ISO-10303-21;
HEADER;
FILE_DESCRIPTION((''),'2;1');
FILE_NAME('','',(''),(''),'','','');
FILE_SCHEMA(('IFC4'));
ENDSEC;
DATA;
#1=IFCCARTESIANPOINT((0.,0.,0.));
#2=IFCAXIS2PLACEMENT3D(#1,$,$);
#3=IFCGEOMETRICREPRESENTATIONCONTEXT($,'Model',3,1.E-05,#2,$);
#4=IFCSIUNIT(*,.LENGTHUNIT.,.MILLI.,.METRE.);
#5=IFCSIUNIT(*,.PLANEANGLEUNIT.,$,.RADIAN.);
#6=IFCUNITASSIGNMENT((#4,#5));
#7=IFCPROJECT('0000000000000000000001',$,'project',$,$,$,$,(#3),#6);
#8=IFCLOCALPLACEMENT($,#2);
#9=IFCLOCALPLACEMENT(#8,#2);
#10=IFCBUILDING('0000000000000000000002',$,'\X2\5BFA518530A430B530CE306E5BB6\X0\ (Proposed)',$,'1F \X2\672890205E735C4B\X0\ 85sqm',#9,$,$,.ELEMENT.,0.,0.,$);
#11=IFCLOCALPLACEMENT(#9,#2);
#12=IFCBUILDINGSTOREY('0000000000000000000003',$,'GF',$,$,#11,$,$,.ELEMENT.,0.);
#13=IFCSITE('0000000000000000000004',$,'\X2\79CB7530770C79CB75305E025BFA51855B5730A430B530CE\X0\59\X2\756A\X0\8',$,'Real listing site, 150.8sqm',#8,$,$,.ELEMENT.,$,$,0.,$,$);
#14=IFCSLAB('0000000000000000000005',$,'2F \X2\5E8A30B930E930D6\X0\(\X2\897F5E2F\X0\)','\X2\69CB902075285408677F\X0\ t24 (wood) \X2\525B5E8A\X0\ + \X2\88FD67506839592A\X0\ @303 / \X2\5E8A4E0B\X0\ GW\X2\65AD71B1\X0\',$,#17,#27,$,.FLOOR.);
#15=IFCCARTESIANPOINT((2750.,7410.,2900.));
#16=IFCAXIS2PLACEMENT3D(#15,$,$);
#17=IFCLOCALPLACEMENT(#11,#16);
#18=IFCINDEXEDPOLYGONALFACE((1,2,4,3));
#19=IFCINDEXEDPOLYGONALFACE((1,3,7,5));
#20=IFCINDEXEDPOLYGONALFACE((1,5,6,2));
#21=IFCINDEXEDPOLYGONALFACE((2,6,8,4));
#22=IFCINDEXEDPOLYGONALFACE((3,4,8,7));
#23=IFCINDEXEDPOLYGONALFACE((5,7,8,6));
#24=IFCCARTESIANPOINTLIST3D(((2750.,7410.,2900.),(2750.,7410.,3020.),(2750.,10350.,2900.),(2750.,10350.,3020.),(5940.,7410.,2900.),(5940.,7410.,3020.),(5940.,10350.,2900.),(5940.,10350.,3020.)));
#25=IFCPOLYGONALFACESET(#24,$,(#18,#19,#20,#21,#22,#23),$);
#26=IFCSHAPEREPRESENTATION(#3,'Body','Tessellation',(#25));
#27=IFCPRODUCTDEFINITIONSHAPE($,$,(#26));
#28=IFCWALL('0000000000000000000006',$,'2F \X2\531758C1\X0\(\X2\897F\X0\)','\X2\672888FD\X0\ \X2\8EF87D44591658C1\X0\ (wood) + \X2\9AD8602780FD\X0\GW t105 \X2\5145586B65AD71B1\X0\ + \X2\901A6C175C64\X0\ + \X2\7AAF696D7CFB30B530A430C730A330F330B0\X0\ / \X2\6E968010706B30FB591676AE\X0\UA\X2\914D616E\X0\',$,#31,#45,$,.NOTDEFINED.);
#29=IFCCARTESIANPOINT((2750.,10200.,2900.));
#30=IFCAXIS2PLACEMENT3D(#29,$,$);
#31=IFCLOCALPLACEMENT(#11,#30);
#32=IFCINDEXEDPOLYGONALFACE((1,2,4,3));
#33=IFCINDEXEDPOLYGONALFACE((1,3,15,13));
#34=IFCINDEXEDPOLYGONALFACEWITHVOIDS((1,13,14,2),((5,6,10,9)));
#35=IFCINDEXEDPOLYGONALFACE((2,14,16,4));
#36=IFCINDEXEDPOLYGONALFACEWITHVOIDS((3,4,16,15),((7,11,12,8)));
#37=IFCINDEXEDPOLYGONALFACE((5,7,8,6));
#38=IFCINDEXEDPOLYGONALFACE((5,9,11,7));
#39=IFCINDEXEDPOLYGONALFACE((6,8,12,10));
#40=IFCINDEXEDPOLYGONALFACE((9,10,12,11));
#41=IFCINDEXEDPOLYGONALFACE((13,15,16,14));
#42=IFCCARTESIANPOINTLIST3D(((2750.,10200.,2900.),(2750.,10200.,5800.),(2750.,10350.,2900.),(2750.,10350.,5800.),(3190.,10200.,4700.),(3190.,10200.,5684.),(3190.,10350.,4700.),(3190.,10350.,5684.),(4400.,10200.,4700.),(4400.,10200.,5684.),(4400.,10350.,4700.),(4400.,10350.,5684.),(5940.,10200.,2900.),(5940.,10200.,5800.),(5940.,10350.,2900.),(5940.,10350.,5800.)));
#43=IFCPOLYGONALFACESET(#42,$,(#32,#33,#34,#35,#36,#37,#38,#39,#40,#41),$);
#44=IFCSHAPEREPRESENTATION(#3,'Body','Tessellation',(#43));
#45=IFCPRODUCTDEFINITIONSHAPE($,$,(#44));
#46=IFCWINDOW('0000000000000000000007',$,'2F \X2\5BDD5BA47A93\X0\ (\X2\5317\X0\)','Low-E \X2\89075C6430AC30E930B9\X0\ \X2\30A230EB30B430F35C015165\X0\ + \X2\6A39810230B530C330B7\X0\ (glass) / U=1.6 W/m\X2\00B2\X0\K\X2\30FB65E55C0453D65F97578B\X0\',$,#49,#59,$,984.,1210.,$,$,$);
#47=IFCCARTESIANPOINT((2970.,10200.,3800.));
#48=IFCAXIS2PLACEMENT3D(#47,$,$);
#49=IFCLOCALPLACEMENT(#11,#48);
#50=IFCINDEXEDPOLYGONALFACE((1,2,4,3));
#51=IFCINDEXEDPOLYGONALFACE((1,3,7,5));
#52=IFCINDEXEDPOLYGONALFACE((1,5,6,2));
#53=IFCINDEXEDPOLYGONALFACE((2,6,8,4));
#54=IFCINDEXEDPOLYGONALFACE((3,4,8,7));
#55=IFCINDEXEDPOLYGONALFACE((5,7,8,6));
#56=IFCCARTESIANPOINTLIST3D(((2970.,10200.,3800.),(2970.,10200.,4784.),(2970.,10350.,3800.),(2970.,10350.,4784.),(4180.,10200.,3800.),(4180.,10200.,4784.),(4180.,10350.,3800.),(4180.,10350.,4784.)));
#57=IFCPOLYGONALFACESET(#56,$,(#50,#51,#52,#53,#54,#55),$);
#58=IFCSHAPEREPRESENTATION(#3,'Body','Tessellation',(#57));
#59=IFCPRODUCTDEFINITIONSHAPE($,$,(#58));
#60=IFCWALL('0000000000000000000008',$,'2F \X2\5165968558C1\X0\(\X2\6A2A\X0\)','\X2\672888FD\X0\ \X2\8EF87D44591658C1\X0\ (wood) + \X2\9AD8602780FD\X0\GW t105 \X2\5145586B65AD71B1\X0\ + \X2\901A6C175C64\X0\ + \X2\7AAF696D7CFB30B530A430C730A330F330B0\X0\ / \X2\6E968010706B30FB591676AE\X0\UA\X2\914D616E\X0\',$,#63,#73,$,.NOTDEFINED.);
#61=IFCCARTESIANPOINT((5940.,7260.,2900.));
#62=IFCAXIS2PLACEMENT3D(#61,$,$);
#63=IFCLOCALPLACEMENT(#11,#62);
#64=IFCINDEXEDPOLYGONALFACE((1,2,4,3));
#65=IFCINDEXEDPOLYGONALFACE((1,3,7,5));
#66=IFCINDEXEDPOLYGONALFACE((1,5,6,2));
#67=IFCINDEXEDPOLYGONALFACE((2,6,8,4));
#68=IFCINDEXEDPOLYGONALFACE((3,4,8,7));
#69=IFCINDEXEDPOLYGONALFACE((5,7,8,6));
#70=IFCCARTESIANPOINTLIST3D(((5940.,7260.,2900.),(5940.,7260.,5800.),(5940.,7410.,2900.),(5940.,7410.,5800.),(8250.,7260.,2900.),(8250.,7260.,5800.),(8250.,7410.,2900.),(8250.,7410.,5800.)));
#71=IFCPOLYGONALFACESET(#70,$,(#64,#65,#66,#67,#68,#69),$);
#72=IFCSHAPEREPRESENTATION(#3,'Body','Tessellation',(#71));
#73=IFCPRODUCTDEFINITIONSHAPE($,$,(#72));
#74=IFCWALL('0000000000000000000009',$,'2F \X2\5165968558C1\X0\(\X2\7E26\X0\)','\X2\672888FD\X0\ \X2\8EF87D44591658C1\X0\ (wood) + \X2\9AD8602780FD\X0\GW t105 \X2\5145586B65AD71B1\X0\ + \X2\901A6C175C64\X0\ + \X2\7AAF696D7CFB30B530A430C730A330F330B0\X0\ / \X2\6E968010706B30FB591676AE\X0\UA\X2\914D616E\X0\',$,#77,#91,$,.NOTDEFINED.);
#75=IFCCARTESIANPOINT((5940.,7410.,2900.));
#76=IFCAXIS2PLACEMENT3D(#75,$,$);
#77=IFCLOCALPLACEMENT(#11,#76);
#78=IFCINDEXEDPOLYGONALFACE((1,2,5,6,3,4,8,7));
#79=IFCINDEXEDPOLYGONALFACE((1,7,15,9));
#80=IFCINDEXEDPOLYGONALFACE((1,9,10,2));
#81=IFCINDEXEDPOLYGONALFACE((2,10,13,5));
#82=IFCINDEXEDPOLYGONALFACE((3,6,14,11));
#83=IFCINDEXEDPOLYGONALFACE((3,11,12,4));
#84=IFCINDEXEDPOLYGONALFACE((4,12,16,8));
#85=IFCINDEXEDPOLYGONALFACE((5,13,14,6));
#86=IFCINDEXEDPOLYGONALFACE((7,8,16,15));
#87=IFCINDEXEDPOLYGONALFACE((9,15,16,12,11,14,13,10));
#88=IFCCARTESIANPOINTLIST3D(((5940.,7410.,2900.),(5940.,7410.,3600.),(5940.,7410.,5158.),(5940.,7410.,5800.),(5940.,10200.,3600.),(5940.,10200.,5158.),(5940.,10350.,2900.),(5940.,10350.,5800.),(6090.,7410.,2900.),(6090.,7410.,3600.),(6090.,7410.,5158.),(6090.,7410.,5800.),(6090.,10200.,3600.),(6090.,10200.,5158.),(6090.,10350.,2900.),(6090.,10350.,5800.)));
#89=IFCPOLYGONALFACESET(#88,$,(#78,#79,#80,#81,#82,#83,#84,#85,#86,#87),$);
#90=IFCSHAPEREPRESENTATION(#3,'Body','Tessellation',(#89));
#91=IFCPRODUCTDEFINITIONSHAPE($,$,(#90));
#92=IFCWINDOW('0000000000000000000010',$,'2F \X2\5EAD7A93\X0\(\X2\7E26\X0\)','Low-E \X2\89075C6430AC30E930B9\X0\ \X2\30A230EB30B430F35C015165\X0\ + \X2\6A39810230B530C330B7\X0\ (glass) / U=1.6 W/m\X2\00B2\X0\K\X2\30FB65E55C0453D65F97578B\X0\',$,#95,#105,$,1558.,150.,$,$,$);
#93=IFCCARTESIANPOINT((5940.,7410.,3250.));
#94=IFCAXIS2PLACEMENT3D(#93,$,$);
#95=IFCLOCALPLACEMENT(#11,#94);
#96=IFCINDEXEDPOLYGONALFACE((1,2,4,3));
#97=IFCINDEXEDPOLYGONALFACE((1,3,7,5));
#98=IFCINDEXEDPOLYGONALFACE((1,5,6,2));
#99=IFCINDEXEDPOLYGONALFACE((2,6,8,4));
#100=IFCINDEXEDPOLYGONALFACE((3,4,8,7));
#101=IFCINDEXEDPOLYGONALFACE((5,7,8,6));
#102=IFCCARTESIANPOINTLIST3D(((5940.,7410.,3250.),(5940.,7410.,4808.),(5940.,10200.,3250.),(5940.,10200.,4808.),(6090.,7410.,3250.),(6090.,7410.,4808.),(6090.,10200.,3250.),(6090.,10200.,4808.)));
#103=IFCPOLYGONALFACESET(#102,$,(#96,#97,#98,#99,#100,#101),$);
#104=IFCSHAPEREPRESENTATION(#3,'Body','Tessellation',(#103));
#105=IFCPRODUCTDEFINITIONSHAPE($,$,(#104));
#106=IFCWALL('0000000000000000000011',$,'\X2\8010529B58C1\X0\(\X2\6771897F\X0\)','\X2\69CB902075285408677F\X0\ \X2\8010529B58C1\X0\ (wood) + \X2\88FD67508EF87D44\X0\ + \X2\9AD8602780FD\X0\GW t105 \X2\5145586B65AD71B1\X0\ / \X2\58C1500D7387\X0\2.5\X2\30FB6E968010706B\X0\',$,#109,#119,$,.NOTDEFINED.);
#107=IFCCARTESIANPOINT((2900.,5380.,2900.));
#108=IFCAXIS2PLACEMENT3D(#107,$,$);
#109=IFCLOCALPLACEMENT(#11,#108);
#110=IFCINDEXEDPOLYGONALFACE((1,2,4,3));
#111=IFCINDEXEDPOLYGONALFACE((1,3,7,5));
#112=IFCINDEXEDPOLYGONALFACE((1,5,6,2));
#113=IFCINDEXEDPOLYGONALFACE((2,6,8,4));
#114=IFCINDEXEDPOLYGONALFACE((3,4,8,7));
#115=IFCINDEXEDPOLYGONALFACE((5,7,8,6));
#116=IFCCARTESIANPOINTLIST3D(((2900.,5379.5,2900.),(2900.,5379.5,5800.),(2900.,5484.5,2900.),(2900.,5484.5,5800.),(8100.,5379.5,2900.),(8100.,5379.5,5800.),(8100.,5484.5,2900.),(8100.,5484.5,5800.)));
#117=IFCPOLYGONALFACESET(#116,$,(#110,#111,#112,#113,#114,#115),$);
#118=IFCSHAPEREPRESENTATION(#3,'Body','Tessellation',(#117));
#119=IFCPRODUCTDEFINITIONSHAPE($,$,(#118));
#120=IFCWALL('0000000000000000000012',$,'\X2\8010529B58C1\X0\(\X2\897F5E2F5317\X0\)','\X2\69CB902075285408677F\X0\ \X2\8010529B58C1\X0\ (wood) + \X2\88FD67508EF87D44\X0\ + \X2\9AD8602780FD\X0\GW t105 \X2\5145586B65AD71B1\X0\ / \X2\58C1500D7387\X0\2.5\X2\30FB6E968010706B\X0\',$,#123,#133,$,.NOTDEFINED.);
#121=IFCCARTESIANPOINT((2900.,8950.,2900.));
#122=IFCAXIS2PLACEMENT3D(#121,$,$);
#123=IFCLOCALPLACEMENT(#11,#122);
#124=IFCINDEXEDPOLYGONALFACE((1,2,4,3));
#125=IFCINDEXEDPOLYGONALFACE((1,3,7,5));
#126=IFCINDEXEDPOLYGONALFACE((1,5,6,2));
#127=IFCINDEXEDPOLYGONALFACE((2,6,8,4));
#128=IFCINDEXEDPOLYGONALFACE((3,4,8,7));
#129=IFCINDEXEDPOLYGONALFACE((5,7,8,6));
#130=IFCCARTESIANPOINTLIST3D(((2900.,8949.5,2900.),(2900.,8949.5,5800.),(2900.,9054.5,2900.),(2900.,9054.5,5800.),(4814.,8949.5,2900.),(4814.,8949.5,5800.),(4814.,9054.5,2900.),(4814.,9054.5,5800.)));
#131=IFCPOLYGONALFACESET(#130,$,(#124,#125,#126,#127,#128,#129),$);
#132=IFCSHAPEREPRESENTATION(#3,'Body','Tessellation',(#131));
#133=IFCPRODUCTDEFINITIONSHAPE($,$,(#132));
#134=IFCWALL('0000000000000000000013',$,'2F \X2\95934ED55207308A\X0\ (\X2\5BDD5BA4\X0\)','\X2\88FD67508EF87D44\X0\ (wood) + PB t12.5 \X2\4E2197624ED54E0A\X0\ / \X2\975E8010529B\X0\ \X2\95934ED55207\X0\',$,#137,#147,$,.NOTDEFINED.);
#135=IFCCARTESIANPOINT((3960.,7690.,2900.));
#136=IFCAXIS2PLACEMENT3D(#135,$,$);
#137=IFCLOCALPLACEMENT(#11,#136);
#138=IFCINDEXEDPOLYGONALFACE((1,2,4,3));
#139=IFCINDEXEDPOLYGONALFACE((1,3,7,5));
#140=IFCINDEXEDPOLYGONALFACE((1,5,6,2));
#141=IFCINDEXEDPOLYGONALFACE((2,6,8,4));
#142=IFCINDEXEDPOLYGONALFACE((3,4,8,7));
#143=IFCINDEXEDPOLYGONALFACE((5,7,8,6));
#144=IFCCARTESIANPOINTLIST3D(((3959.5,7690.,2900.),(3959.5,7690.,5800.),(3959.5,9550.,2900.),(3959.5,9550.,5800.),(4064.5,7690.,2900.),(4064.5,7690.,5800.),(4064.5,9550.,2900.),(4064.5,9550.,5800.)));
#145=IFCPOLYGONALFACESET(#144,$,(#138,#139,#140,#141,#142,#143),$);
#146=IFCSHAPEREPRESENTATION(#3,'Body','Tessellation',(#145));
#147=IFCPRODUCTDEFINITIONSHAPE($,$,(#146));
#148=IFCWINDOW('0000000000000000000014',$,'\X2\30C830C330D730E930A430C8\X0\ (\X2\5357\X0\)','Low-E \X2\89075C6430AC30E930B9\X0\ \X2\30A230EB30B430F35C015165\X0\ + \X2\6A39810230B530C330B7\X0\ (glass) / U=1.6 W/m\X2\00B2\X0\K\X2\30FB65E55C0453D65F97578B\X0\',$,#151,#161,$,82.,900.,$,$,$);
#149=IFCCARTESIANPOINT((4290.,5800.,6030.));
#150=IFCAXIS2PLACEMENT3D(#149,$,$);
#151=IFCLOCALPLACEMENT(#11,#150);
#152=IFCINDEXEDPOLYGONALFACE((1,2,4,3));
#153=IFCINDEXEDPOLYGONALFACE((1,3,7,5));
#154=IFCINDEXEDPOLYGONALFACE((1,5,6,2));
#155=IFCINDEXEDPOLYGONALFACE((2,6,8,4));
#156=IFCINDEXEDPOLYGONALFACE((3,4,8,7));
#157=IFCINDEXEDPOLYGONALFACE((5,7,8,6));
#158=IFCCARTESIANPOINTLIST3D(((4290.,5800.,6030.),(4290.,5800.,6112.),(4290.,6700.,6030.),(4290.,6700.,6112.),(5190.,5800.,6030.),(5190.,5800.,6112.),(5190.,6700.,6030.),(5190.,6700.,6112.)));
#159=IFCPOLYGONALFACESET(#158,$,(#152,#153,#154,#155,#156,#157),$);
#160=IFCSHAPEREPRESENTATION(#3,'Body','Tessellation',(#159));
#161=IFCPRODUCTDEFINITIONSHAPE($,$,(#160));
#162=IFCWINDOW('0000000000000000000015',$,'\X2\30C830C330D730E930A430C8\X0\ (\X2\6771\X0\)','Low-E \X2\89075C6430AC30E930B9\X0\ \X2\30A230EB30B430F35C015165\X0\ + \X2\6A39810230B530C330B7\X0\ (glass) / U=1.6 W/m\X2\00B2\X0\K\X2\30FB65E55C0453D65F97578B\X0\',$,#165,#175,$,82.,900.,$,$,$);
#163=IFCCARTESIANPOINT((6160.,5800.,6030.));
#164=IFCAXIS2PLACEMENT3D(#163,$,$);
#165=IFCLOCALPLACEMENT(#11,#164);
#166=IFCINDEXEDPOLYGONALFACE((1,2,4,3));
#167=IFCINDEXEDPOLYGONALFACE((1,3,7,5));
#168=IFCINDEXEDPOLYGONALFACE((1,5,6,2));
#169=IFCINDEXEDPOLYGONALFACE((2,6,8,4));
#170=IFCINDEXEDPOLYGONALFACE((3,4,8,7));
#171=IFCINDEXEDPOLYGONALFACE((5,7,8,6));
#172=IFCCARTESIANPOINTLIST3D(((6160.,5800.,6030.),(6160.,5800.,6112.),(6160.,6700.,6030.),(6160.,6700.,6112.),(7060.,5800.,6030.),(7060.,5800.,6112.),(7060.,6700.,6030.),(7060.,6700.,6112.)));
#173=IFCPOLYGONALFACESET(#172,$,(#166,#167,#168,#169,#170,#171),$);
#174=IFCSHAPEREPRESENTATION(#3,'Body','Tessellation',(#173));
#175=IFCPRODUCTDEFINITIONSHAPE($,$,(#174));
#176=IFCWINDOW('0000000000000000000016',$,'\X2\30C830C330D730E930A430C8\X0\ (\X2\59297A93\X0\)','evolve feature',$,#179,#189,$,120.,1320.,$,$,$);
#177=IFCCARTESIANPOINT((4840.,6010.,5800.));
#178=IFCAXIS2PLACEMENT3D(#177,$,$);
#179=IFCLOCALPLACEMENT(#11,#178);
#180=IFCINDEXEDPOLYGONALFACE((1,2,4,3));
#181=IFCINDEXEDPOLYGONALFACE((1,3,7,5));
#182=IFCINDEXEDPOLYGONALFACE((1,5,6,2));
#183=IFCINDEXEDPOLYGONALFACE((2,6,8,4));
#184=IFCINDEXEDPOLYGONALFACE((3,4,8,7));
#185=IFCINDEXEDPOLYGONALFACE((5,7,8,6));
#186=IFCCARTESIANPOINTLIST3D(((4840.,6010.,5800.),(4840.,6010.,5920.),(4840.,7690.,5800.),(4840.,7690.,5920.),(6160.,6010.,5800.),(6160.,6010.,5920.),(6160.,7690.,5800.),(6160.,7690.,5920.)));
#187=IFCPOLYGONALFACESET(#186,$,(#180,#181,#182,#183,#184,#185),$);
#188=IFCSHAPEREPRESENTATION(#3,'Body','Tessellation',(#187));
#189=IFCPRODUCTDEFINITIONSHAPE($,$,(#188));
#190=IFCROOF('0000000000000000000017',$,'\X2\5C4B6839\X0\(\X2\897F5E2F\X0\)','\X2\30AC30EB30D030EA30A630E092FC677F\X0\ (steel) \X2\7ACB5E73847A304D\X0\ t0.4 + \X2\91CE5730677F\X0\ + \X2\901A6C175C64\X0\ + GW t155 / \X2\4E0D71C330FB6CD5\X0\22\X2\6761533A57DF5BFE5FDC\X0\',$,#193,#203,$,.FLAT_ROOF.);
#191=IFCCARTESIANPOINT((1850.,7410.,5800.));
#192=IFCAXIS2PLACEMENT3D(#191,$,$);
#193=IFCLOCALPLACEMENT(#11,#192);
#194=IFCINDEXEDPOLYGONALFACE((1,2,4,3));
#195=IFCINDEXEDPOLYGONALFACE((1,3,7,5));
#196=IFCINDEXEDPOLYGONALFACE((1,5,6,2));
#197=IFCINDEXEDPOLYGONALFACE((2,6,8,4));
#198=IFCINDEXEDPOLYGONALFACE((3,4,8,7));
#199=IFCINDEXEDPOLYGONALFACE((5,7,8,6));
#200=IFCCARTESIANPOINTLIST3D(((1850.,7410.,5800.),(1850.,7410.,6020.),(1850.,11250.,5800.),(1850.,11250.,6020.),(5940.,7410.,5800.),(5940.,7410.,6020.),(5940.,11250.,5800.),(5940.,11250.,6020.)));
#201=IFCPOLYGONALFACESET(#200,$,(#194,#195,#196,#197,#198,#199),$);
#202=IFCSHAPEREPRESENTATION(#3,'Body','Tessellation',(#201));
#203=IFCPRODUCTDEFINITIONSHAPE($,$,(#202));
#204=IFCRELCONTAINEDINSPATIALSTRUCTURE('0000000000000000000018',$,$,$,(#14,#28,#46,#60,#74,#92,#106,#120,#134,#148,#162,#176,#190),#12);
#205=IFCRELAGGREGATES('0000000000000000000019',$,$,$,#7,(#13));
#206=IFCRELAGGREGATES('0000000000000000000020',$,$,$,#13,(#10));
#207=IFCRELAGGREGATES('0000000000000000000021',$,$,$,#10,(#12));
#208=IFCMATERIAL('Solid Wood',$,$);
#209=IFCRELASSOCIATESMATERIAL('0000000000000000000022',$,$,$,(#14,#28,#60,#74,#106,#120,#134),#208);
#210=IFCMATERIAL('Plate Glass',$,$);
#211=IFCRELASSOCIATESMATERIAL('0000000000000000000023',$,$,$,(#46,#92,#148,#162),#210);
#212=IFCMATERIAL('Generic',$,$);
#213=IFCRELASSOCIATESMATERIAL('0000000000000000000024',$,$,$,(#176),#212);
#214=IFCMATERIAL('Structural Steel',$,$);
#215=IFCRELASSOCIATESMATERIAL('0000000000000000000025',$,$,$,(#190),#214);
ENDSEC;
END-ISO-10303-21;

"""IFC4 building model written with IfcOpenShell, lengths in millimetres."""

from ifc_helpers import new_model, si_unit, frame, frame_2d, origin, place, context, project, spatial, rectangle, extrude, material, element, fill, save


model = new_model("IFC4")

# Units and contexts
model_context = context("Model", 3, precision=1e-05, world=origin())
ifc_project = project(units=[si_unit("LENGTHUNIT", "METRE", prefix="MILLI"), si_unit("PLANEANGLEUNIT", "RADIAN")], contexts=[model_context])

# Site, building, storey
site_placement = place(None, origin())
site = spatial("IfcSite", under=ifc_project, at=site_placement, Name="秋田県秋田市寺内字イサノ59番8", ObjectType="Real listing site, 150.8sqm", CompositionType="ELEMENT", RefElevation=0.0)
building_placement = place(site_placement, origin())
building = spatial("IfcBuilding", under=site, at=building_placement, Name="寺内イサノの家 (Proposed)", ObjectType="1F 木造平屋 85sqm", CompositionType="ELEMENT", ElevationOfRefHeight=0.0, ElevationOfTerrain=0.0)
storey_placement = place(building_placement, origin())
storey = spatial("IfcBuildingStorey", under=building, at=storey_placement, Name="GF", CompositionType="ELEMENT", Elevation=0.0)

# Slab
ifc_material_1 = material(Name="Solid Wood")
slab_placement = place(storey_placement, frame((2750.0, 7410.0, 2900.0)))
element("IfcSlab", 1, at=slab_placement, inside=storey, material=ifc_material_1, Name="2F 床スラブ(西帯)", Description="構造用合板 t24 (wood) 剛床 + 製材根太 @303 / 床下 GW断熱", PredefinedType="FLOOR", context=model_context, shape_type="SweptSolid", body=[
    extrude(rectangle(XDim=3190.0, YDim=2940.0, at=frame_2d((1595.0, 1470.0))), frame((2750.0, 7410.0, 2900.0)), (0.0, 0.0, 1.0), 120.0),
])

# Wall, opening, window
wall_1_placement = place(storey_placement, frame((2750.0, 10200.0, 2900.0)))
wall_1 = element("IfcWall", 2, at=wall_1_placement, inside=storey, material=ifc_material_1, Name="2F 北壁(西)", Description="木製 軸組外壁 (wood) + 高性能GW t105 充填断熱 + 通気層 + 窯業系サイディング / 準耐火・外皮UA配慮", PredefinedType="NOTDEFINED", context=model_context, shape_type="SweptSolid", body=[
    extrude(rectangle(XDim=3190.0, YDim=150.0, at=frame_2d((1595.0, 75.0))), frame((2750.0, 10200.0, 2900.0)), (0.0, 0.0, 1.0), 2900.0),
])
opening_1_placement = place(storey_placement, frame((2970.0, 10200.0, 3800.0)))
opening_1 = element("IfcOpeningElement", 3, at=opening_1_placement, cuts=wall_1, PredefinedType="NOTDEFINED", context=model_context, shape_type="SweptSolid", body=[
    extrude(rectangle(XDim=1210.0, YDim=150.0, at=frame_2d((605.0, 75.0))), frame((2970.0, 10200.0, 3800.0)), (0.0, 0.0, 1.0), 984.0),
])
ifc_material_2 = material(Name="Plate Glass")
window_1_placement = place(storey_placement, frame((2970.0, 10200.0, 3800.0)))
window_1 = element("IfcWindow", 4, at=window_1_placement, inside=storey, material=ifc_material_2, Name="2F 寝室窓 (北)", Description="Low-E 複層ガラス アルゴン封入 + 樹脂サッシ (glass) / U=1.6 W/m²K・日射取得型", OverallHeight=984.0, OverallWidth=1210.0, context=model_context, shape_type="SweptSolid", body=[
    extrude(rectangle(XDim=1210.0, YDim=150.0, at=frame_2d((605.0, 75.0))), frame((2970.0, 10200.0, 3800.0)), (0.0, 0.0, 1.0), 984.0),
])
fill(opening_1, window_1)

# Wall
wall_2_placement = place(storey_placement, frame((5940.0, 7260.0, 2900.0)))
element("IfcWall", 5, at=wall_2_placement, inside=storey, material=ifc_material_1, Name="2F 入隅壁(横)", Description="木製 軸組外壁 (wood) + 高性能GW t105 充填断熱 + 通気層 + 窯業系サイディング / 準耐火・外皮UA配慮", PredefinedType="NOTDEFINED", context=model_context, shape_type="SweptSolid", body=[
    extrude(rectangle(XDim=2310.0, YDim=150.0, at=frame_2d((1155.0, 75.0))), frame((5940.0, 7260.0, 2900.0)), (0.0, 0.0, 1.0), 2900.0),
])

# Wall, opening, window
wall_3_placement = place(storey_placement, frame((5940.0, 7410.0, 2900.0)))
wall_3 = element("IfcWall", 6, at=wall_3_placement, inside=storey, material=ifc_material_1, Name="2F 入隅壁(縦)", Description="木製 軸組外壁 (wood) + 高性能GW t105 充填断熱 + 通気層 + 窯業系サイディング / 準耐火・外皮UA配慮", PredefinedType="NOTDEFINED", context=model_context, shape_type="SweptSolid", body=[
    extrude(rectangle(XDim=150.0, YDim=2940.0, at=frame_2d((75.0, 1470.0))), frame((5940.0, 7410.0, 2900.0)), (0.0, 0.0, 1.0), 2900.0),
])
opening_2_placement = place(storey_placement, frame((5940.0, 7410.0, 3250.0)))
opening_2 = element("IfcOpeningElement", 7, at=opening_2_placement, cuts=wall_3, PredefinedType="NOTDEFINED", context=model_context, shape_type="SweptSolid", body=[
    extrude(rectangle(XDim=150.0, YDim=2790.0, at=frame_2d((75.0, 1395.0))), frame((5940.0, 7410.0, 3250.0)), (0.0, 0.0, 1.0), 1558.0),
])
window_2_placement = place(storey_placement, frame((5940.0, 7410.0, 3250.0)))
window_2 = element("IfcWindow", 8, at=window_2_placement, inside=storey, material=ifc_material_2, Name="2F 庭窓(縦)", Description="Low-E 複層ガラス アルゴン封入 + 樹脂サッシ (glass) / U=1.6 W/m²K・日射取得型", OverallHeight=1558.0, OverallWidth=150.0, context=model_context, shape_type="SweptSolid", body=[
    extrude(rectangle(XDim=150.0, YDim=2790.0, at=frame_2d((75.0, 1395.0))), frame((5940.0, 7410.0, 3250.0)), (0.0, 0.0, 1.0), 1558.0),
])
fill(opening_2, window_2)

# Walls
wall_4_placement = place(storey_placement, frame((2900.0, 5380.0, 2900.0)))
element("IfcWall", 9, at=wall_4_placement, inside=storey, material=ifc_material_1, Name="耐力壁(東西)", Description="構造用合板 耐力壁 (wood) + 製材軸組 + 高性能GW t105 充填断熱 / 壁倍率2.5・準耐火", PredefinedType="NOTDEFINED", context=model_context, shape_type="SweptSolid", body=[
    extrude(rectangle(XDim=5200.0, YDim=105.0, at=frame_2d((2600.0, 52.0))), frame((2900.0, 5380.0, 2900.0)), (0.0, 0.0, 1.0), 2900.0),
])
wall_5_placement = place(storey_placement, frame((2900.0, 8950.0, 2900.0)))
element("IfcWall", 10, at=wall_5_placement, inside=storey, material=ifc_material_1, Name="耐力壁(西帯北)", Description="構造用合板 耐力壁 (wood) + 製材軸組 + 高性能GW t105 充填断熱 / 壁倍率2.5・準耐火", PredefinedType="NOTDEFINED", context=model_context, shape_type="SweptSolid", body=[
    extrude(rectangle(XDim=1914.0, YDim=105.0, at=frame_2d((957.0, 52.0))), frame((2900.0, 8950.0, 2900.0)), (0.0, 0.0, 1.0), 2900.0),
])
wall_6_placement = place(storey_placement, frame((3960.0, 7690.0, 2900.0)))
element("IfcWall", 11, at=wall_6_placement, inside=storey, material=ifc_material_1, Name="2F 間仕切り (寝室)", Description="製材軸組 (wood) + PB t12.5 両面仕上 / 非耐力 間仕切", PredefinedType="NOTDEFINED", context=model_context, shape_type="SweptSolid", body=[
    extrude(rectangle(XDim=105.0, YDim=1860.0, at=frame_2d((52.0, 930.0))), frame((3960.0, 7690.0, 2900.0)), (0.0, 0.0, 1.0), 2900.0),
])

# Windows
window_3_placement = place(storey_placement, frame((4290.0, 5800.0, 6030.0)))
element("IfcWindow", 12, at=window_3_placement, inside=storey, material=ifc_material_2, Name="トップライト (南)", Description="Low-E 複層ガラス アルゴン封入 + 樹脂サッシ (glass) / U=1.6 W/m²K・日射取得型", OverallHeight=82.0, OverallWidth=900.0, context=model_context, shape_type="SweptSolid", body=[
    extrude(rectangle(XDim=900.0, YDim=900.0, at=frame_2d((450.0, 450.0))), frame((4290.0, 5800.0, 6030.0)), (0.0, 0.0, 1.0), 82.0),
])
window_4_placement = place(storey_placement, frame((6160.0, 5800.0, 6030.0)))
element("IfcWindow", 13, at=window_4_placement, inside=storey, material=ifc_material_2, Name="トップライト (東)", Description="Low-E 複層ガラス アルゴン封入 + 樹脂サッシ (glass) / U=1.6 W/m²K・日射取得型", OverallHeight=82.0, OverallWidth=900.0, context=model_context, shape_type="SweptSolid", body=[
    extrude(rectangle(XDim=900.0, YDim=900.0, at=frame_2d((450.0, 450.0))), frame((6160.0, 5800.0, 6030.0)), (0.0, 0.0, 1.0), 82.0),
])
ifc_material_3 = material(Name="Generic")
window_5_placement = place(storey_placement, frame((4840.0, 6010.0, 5800.0)))
element("IfcWindow", 14, at=window_5_placement, inside=storey, material=ifc_material_3, Name="トップライト (天窓)", Description="evolve feature", OverallHeight=120.0, OverallWidth=1320.0, context=model_context, shape_type="SweptSolid", body=[
    extrude(rectangle(XDim=1320.0, YDim=1680.0, at=frame_2d((660.0, 840.0))), frame((4840.0, 6010.0, 5800.0)), (0.0, 0.0, 1.0), 120.0),
])

# Roof
ifc_material_4 = material(Name="Structural Steel")
for number, where, name in (
    (15, (1850.0, 7410.0, 5800.0), "屋根(西帯)"),
):
    element("IfcRoof", number, at=place(storey_placement, frame(where)), inside=storey, material=ifc_material_4, Name=name, Description="ガルバリウム鋼板 (steel) 立平葺き t0.4 + 野地板 + 通気層 + GW t155 / 不燃・法22条区域対応", PredefinedType="FLAT_ROOF", context=model_context, shape_type="SweptSolid", body=[
        extrude(rectangle(XDim=4090.0, YDim=3840.0, at=frame_2d((2045.0, 1920.0))), frame((1850.0, 7410.0, 5800.0)), (0.0, 0.0, 1.0), 220.0),
    ])

save(model, "model.ifc")
